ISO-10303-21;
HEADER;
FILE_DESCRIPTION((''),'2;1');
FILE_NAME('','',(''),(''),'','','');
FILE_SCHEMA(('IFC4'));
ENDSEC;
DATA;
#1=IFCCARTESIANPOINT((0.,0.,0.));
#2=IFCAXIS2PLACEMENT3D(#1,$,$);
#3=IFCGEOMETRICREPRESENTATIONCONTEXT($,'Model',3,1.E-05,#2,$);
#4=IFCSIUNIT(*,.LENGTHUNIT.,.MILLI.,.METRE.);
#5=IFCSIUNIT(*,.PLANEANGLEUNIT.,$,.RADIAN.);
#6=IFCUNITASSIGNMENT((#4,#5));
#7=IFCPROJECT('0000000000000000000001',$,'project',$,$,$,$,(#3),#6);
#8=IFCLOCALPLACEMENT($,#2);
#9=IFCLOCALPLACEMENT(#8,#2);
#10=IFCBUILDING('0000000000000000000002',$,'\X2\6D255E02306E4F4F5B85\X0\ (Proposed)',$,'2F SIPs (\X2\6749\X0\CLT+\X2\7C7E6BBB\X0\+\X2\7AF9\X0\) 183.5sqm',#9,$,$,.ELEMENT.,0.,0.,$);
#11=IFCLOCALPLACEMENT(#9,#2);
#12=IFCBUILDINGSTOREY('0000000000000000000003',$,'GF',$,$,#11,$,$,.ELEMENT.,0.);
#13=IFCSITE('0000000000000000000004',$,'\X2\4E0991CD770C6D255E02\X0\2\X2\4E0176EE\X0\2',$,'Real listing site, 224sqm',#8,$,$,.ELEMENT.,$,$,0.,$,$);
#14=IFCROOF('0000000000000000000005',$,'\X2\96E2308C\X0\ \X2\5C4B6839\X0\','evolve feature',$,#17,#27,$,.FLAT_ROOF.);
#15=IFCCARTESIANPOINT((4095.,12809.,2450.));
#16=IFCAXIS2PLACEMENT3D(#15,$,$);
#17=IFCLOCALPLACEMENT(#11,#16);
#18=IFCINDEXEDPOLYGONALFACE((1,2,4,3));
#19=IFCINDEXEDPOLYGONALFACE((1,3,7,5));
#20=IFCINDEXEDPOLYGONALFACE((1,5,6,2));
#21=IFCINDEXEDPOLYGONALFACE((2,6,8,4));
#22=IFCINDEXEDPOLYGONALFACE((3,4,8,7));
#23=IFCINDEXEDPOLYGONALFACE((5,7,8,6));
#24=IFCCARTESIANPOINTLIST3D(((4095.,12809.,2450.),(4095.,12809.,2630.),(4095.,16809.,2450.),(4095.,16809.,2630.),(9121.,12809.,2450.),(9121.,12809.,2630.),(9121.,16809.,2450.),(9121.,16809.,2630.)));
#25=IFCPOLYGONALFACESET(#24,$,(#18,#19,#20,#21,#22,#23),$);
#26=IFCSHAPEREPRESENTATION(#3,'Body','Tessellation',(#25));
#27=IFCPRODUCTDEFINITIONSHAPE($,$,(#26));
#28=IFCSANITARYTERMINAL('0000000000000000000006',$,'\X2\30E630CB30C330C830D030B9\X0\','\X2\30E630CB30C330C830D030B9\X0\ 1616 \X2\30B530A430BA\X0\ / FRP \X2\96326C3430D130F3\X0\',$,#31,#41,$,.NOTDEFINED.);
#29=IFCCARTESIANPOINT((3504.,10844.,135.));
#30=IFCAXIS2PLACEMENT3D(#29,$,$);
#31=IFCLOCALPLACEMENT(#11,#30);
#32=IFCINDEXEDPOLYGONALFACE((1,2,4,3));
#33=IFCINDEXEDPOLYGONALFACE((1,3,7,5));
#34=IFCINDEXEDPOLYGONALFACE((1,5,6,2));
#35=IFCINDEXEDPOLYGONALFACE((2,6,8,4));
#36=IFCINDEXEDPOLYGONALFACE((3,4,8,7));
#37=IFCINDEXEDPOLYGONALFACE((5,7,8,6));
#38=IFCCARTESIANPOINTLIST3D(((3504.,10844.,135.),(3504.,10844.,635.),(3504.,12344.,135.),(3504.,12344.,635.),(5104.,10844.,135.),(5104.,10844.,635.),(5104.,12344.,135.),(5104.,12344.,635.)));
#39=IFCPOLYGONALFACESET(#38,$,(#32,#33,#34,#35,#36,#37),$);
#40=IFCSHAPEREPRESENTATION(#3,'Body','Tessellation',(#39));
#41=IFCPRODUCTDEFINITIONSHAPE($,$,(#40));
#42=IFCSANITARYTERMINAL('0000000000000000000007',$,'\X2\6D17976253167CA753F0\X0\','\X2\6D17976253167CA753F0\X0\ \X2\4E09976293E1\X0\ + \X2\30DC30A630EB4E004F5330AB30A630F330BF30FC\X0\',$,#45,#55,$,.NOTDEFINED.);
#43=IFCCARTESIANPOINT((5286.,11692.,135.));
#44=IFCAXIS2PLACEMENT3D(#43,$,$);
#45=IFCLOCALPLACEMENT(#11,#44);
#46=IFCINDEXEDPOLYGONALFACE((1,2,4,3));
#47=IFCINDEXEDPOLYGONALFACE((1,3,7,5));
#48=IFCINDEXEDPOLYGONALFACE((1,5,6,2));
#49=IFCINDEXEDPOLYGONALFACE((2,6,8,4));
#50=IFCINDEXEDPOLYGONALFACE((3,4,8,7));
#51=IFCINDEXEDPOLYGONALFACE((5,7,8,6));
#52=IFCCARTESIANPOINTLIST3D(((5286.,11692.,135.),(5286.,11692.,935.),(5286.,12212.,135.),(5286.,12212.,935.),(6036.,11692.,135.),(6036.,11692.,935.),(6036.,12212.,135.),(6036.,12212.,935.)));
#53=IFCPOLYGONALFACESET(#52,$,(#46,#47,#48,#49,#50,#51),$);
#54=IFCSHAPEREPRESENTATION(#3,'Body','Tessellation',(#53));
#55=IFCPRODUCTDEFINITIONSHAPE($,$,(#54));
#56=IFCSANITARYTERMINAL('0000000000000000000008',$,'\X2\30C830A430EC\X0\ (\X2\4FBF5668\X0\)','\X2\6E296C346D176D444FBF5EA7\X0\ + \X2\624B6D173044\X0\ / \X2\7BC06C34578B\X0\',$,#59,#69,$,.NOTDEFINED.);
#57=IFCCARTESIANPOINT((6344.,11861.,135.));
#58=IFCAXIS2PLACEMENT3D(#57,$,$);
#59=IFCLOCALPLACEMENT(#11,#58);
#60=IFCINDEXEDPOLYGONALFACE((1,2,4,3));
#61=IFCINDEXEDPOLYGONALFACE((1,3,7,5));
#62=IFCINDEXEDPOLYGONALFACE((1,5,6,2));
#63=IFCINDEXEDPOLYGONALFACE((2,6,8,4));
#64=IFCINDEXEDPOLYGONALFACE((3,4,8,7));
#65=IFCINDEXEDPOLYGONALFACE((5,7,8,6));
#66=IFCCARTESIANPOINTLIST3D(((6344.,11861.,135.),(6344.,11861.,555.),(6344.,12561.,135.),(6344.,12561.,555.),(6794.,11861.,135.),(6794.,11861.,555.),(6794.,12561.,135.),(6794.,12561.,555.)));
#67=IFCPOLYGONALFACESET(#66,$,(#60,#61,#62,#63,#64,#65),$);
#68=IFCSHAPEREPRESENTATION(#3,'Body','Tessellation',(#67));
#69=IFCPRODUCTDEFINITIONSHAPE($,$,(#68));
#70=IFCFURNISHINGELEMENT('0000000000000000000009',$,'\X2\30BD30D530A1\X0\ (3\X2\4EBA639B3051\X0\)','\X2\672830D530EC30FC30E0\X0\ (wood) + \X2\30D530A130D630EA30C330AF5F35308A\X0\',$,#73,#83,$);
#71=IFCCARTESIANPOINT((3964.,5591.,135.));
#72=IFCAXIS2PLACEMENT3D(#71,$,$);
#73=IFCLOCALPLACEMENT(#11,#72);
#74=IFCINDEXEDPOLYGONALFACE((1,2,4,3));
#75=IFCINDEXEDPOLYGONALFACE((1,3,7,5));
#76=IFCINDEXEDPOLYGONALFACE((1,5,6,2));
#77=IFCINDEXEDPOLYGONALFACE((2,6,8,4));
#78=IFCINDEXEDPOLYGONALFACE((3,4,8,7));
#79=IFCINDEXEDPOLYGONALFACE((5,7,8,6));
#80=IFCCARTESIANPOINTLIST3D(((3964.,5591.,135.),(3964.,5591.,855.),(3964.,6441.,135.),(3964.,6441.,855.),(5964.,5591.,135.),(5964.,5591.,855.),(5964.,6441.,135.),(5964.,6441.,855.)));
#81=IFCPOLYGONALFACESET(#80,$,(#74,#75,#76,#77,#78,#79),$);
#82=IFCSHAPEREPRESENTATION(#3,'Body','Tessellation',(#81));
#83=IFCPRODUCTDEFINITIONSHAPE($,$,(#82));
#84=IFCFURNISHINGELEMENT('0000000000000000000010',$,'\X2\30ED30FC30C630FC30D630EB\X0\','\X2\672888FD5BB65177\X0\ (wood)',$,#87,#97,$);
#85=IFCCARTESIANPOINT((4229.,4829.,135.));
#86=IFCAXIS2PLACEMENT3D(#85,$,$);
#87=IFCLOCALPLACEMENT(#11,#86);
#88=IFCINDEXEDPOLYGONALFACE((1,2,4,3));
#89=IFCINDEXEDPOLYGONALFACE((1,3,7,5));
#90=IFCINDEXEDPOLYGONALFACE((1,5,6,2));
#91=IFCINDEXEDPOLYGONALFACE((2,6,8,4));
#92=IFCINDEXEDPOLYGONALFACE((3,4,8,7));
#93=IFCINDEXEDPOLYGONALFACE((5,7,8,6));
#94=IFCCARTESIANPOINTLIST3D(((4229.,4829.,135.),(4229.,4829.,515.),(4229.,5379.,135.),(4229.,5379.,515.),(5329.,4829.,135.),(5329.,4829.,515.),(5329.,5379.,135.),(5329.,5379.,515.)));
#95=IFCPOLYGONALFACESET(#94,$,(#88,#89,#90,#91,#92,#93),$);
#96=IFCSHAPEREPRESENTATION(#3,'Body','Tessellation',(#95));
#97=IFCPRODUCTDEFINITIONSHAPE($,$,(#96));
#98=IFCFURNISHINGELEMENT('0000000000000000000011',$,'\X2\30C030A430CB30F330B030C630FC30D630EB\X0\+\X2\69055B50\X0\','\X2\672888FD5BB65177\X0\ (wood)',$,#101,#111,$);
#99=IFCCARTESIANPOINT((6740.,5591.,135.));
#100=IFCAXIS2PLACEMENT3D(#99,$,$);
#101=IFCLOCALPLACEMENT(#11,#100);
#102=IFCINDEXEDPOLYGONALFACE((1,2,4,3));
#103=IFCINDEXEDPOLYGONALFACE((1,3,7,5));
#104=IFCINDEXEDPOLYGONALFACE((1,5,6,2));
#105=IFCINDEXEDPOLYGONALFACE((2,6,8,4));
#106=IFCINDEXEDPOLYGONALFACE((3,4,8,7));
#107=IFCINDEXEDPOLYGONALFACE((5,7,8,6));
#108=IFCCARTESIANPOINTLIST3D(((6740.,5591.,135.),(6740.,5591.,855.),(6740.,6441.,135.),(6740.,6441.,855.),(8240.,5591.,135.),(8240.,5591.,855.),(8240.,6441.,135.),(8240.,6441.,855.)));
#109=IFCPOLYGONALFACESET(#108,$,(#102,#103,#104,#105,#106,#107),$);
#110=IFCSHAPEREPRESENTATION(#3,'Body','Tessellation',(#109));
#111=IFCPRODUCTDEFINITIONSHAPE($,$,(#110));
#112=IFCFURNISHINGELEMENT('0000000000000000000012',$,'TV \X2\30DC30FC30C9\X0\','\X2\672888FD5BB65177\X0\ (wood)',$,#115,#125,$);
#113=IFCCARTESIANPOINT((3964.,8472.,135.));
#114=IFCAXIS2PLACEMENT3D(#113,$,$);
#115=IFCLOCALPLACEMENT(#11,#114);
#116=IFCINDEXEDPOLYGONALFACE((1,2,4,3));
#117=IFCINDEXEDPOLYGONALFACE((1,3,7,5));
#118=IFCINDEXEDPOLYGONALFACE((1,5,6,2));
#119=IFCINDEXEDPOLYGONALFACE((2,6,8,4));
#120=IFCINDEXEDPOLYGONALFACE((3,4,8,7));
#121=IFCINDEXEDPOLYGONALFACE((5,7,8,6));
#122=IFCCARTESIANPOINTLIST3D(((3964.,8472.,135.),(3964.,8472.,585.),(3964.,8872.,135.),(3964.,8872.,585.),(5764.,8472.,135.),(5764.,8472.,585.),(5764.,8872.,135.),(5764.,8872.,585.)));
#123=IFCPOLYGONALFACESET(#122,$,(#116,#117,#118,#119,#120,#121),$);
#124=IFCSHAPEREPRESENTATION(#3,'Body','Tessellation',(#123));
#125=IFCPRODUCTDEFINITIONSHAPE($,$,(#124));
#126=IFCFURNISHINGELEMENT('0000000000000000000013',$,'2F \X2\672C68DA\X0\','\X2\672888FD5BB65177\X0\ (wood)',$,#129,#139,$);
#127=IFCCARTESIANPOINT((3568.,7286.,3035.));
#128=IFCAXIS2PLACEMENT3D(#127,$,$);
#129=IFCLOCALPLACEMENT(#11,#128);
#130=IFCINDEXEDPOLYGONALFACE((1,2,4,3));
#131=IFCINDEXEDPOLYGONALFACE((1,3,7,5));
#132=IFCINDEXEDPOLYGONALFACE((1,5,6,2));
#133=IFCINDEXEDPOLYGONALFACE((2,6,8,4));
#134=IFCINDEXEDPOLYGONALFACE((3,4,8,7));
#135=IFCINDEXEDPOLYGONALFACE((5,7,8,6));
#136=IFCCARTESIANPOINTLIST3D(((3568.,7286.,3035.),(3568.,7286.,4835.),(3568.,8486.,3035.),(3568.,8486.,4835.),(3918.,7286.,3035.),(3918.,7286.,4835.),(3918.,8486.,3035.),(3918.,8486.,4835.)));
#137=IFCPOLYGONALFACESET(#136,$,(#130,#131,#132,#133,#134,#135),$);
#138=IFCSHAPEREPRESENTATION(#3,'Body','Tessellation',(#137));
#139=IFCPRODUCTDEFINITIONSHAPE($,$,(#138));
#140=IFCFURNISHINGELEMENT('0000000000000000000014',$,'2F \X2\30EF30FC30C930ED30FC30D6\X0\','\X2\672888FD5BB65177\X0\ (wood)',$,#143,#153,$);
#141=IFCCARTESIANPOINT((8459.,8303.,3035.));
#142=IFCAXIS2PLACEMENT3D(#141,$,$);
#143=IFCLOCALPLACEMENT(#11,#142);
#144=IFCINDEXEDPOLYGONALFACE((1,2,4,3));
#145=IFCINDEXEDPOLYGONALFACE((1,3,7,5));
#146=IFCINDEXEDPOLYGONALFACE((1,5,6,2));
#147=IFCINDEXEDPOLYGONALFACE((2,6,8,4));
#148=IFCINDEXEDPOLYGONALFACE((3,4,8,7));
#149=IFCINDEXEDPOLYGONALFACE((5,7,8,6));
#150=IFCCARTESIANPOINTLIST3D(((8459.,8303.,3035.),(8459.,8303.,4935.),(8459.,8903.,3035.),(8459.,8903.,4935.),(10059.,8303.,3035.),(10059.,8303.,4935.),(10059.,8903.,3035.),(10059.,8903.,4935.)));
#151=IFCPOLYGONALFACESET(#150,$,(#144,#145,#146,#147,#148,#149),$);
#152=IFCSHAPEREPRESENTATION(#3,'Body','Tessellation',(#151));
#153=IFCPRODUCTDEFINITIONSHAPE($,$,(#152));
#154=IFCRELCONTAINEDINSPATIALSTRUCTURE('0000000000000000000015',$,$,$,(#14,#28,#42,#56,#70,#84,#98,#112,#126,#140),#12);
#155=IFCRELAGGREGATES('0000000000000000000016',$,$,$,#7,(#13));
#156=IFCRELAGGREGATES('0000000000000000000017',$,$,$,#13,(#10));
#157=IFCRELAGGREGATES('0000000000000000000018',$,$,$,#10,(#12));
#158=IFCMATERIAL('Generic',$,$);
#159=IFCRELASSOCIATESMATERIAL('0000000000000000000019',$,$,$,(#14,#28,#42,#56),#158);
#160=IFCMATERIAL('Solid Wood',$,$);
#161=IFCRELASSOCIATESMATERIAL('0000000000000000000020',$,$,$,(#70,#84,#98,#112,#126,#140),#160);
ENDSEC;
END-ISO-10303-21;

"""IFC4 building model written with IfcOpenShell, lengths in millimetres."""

from ifc_helpers import new_model, si_unit, frame, frame_2d, origin, place, context, project, spatial, rectangle, extrude, material, element, save


model = new_model("IFC4")

# Units and contexts
model_context = context("Model", 3, precision=1e-05, world=origin())
ifc_project = project(units=[si_unit("LENGTHUNIT", "METRE", prefix="MILLI"), si_unit("PLANEANGLEUNIT", "RADIAN")], contexts=[model_context])

# Site, building, storey
site_placement = place(None, origin())
site = spatial("IfcSite", under=ifc_project, at=site_placement, Name="三重県津市2丁目2", ObjectType="Real listing site, 224sqm", CompositionType="ELEMENT", RefElevation=0.0)
building_placement = place(site_placement, origin())
building = spatial("IfcBuilding", under=site, at=building_placement, Name="津市の住宅 (Proposed)", ObjectType="2F SIPs (杉CLT+籾殻+竹) 183.5sqm", CompositionType="ELEMENT", ElevationOfRefHeight=0.0, ElevationOfTerrain=0.0)
storey_placement = place(building_placement, origin())
storey = spatial("IfcBuildingStorey", under=building, at=storey_placement, Name="GF", CompositionType="ELEMENT", Elevation=0.0)

# Shared definitions
ifc_material_1 = material(Name="Generic")

# Shared definitions
ifc_material_2 = material(Name="Solid Wood")

# Roof
roof_placement = place(storey_placement, frame((4095.0, 12809.0, 2450.0)))
element("IfcRoof", 1, at=roof_placement, inside=storey, material=ifc_material_1, Name="離れ 屋根", Description="evolve feature", PredefinedType="FLAT_ROOF", context=model_context, shape_type="SweptSolid", body=[
    extrude(rectangle(XDim=5026.0, YDim=4000.0, at=frame_2d((2513.0, 2000.0))), frame((4095.0, 12809.0, 2450.0)), (0.0, 0.0, 1.0), 180.0),
])

# Sanitary terminals
sanitary_terminal_1_placement = place(storey_placement, frame((3504.0, 10844.0, 135.0)))
element("IfcSanitaryTerminal", 2, at=sanitary_terminal_1_placement, inside=storey, material=ifc_material_1, Name="ユニットバス", Description="ユニットバス 1616 サイズ / FRP 防水パン", PredefinedType="NOTDEFINED", context=model_context, shape_type="SweptSolid", body=[
    extrude(rectangle(XDim=1600.0, YDim=1500.0, at=frame_2d((800.0, 750.0))), frame((3504.0, 10844.0, 135.0)), (0.0, 0.0, 1.0), 500.0),
])
sanitary_terminal_2_placement = place(storey_placement, frame((5286.0, 11692.0, 135.0)))
element("IfcSanitaryTerminal", 3, at=sanitary_terminal_2_placement, inside=storey, material=ifc_material_1, Name="洗面化粧台", Description="洗面化粧台 三面鏡 + ボウル一体カウンター", PredefinedType="NOTDEFINED", context=model_context, shape_type="SweptSolid", body=[
    extrude(rectangle(XDim=750.0, YDim=520.0, at=frame_2d((375.0, 260.0))), frame((5286.0, 11692.0, 135.0)), (0.0, 0.0, 1.0), 800.0),
])
sanitary_terminal_3_placement = place(storey_placement, frame((6344.0, 11861.0, 135.0)))
element("IfcSanitaryTerminal", 4, at=sanitary_terminal_3_placement, inside=storey, material=ifc_material_1, Name="トイレ (便器)", Description="温水洗浄便座 + 手洗い / 節水型", PredefinedType="NOTDEFINED", context=model_context, shape_type="SweptSolid", body=[
    extrude(rectangle(XDim=450.0, YDim=700.0, at=frame_2d((225.0, 350.0))), frame((6344.0, 11861.0, 135.0)), (0.0, 0.0, 1.0), 420.0),
])

# Furnishing elements
furnishing_1_placement = place(storey_placement, frame((3964.0, 5591.0, 135.0)))
element("IfcFurnishingElement", 5, at=furnishing_1_placement, inside=storey, material=ifc_material_2, Name="ソファ (3人掛け)", Description="木フレーム (wood) + ファブリック張り", context=model_context, shape_type="SweptSolid", body=[
    extrude(rectangle(XDim=2000.0, YDim=850.0, at=frame_2d((1000.0, 425.0))), frame((3964.0, 5591.0, 135.0)), (0.0, 0.0, 1.0), 720.0),
])
furnishing_2_placement = place(storey_placement, frame((4229.0, 4829.0, 135.0)))
element("IfcFurnishingElement", 6, at=furnishing_2_placement, inside=storey, material=ifc_material_2, Name="ローテーブル", Description="木製家具 (wood)", context=model_context, shape_type="SweptSolid", body=[
    extrude(rectangle(XDim=1100.0, YDim=550.0, at=frame_2d((550.0, 275.0))), frame((4229.0, 4829.0, 135.0)), (0.0, 0.0, 1.0), 380.0),
])
furnishing_3_placement = place(storey_placement, frame((6740.0, 5591.0, 135.0)))
element("IfcFurnishingElement", 7, at=furnishing_3_placement, inside=storey, material=ifc_material_2, Name="ダイニングテーブル+椅子", Description="木製家具 (wood)", context=model_context, shape_type="SweptSolid", body=[
    extrude(rectangle(XDim=1500.0, YDim=850.0, at=frame_2d((750.0, 425.0))), frame((6740.0, 5591.0, 135.0)), (0.0, 0.0, 1.0), 720.0),
])
furnishing_4_placement = place(storey_placement, frame((3964.0, 8472.0, 135.0)))
element("IfcFurnishingElement", 8, at=furnishing_4_placement, inside=storey, material=ifc_material_2, Name="TV ボード", Description="木製家具 (wood)", context=model_context, shape_type="SweptSolid", body=[
    extrude(rectangle(XDim=1800.0, YDim=400.0, at=frame_2d((900.0, 200.0))), frame((3964.0, 8472.0, 135.0)), (0.0, 0.0, 1.0), 450.0),
])
furnishing_5_placement = place(storey_placement, frame((3568.0, 7286.0, 3035.0)))
element("IfcFurnishingElement", 9, at=furnishing_5_placement, inside=storey, material=ifc_material_2, Name="2F 本棚", Description="木製家具 (wood)", context=model_context, shape_type="SweptSolid", body=[
    extrude(rectangle(XDim=350.0, YDim=1200.0, at=frame_2d((175.0, 600.0))), frame((3568.0, 7286.0, 3035.0)), (0.0, 0.0, 1.0), 1800.0),
])
furnishing_6_placement = place(storey_placement, frame((8459.0, 8303.0, 3035.0)))
element("IfcFurnishingElement", 10, at=furnishing_6_placement, inside=storey, material=ifc_material_2, Name="2F ワードローブ", Description="木製家具 (wood)", context=model_context, shape_type="SweptSolid", body=[
    extrude(rectangle(XDim=1600.0, YDim=600.0, at=frame_2d((800.0, 300.0))), frame((8459.0, 8303.0, 3035.0)), (0.0, 0.0, 1.0), 1900.0),
])

save(model, "model.ifc")
